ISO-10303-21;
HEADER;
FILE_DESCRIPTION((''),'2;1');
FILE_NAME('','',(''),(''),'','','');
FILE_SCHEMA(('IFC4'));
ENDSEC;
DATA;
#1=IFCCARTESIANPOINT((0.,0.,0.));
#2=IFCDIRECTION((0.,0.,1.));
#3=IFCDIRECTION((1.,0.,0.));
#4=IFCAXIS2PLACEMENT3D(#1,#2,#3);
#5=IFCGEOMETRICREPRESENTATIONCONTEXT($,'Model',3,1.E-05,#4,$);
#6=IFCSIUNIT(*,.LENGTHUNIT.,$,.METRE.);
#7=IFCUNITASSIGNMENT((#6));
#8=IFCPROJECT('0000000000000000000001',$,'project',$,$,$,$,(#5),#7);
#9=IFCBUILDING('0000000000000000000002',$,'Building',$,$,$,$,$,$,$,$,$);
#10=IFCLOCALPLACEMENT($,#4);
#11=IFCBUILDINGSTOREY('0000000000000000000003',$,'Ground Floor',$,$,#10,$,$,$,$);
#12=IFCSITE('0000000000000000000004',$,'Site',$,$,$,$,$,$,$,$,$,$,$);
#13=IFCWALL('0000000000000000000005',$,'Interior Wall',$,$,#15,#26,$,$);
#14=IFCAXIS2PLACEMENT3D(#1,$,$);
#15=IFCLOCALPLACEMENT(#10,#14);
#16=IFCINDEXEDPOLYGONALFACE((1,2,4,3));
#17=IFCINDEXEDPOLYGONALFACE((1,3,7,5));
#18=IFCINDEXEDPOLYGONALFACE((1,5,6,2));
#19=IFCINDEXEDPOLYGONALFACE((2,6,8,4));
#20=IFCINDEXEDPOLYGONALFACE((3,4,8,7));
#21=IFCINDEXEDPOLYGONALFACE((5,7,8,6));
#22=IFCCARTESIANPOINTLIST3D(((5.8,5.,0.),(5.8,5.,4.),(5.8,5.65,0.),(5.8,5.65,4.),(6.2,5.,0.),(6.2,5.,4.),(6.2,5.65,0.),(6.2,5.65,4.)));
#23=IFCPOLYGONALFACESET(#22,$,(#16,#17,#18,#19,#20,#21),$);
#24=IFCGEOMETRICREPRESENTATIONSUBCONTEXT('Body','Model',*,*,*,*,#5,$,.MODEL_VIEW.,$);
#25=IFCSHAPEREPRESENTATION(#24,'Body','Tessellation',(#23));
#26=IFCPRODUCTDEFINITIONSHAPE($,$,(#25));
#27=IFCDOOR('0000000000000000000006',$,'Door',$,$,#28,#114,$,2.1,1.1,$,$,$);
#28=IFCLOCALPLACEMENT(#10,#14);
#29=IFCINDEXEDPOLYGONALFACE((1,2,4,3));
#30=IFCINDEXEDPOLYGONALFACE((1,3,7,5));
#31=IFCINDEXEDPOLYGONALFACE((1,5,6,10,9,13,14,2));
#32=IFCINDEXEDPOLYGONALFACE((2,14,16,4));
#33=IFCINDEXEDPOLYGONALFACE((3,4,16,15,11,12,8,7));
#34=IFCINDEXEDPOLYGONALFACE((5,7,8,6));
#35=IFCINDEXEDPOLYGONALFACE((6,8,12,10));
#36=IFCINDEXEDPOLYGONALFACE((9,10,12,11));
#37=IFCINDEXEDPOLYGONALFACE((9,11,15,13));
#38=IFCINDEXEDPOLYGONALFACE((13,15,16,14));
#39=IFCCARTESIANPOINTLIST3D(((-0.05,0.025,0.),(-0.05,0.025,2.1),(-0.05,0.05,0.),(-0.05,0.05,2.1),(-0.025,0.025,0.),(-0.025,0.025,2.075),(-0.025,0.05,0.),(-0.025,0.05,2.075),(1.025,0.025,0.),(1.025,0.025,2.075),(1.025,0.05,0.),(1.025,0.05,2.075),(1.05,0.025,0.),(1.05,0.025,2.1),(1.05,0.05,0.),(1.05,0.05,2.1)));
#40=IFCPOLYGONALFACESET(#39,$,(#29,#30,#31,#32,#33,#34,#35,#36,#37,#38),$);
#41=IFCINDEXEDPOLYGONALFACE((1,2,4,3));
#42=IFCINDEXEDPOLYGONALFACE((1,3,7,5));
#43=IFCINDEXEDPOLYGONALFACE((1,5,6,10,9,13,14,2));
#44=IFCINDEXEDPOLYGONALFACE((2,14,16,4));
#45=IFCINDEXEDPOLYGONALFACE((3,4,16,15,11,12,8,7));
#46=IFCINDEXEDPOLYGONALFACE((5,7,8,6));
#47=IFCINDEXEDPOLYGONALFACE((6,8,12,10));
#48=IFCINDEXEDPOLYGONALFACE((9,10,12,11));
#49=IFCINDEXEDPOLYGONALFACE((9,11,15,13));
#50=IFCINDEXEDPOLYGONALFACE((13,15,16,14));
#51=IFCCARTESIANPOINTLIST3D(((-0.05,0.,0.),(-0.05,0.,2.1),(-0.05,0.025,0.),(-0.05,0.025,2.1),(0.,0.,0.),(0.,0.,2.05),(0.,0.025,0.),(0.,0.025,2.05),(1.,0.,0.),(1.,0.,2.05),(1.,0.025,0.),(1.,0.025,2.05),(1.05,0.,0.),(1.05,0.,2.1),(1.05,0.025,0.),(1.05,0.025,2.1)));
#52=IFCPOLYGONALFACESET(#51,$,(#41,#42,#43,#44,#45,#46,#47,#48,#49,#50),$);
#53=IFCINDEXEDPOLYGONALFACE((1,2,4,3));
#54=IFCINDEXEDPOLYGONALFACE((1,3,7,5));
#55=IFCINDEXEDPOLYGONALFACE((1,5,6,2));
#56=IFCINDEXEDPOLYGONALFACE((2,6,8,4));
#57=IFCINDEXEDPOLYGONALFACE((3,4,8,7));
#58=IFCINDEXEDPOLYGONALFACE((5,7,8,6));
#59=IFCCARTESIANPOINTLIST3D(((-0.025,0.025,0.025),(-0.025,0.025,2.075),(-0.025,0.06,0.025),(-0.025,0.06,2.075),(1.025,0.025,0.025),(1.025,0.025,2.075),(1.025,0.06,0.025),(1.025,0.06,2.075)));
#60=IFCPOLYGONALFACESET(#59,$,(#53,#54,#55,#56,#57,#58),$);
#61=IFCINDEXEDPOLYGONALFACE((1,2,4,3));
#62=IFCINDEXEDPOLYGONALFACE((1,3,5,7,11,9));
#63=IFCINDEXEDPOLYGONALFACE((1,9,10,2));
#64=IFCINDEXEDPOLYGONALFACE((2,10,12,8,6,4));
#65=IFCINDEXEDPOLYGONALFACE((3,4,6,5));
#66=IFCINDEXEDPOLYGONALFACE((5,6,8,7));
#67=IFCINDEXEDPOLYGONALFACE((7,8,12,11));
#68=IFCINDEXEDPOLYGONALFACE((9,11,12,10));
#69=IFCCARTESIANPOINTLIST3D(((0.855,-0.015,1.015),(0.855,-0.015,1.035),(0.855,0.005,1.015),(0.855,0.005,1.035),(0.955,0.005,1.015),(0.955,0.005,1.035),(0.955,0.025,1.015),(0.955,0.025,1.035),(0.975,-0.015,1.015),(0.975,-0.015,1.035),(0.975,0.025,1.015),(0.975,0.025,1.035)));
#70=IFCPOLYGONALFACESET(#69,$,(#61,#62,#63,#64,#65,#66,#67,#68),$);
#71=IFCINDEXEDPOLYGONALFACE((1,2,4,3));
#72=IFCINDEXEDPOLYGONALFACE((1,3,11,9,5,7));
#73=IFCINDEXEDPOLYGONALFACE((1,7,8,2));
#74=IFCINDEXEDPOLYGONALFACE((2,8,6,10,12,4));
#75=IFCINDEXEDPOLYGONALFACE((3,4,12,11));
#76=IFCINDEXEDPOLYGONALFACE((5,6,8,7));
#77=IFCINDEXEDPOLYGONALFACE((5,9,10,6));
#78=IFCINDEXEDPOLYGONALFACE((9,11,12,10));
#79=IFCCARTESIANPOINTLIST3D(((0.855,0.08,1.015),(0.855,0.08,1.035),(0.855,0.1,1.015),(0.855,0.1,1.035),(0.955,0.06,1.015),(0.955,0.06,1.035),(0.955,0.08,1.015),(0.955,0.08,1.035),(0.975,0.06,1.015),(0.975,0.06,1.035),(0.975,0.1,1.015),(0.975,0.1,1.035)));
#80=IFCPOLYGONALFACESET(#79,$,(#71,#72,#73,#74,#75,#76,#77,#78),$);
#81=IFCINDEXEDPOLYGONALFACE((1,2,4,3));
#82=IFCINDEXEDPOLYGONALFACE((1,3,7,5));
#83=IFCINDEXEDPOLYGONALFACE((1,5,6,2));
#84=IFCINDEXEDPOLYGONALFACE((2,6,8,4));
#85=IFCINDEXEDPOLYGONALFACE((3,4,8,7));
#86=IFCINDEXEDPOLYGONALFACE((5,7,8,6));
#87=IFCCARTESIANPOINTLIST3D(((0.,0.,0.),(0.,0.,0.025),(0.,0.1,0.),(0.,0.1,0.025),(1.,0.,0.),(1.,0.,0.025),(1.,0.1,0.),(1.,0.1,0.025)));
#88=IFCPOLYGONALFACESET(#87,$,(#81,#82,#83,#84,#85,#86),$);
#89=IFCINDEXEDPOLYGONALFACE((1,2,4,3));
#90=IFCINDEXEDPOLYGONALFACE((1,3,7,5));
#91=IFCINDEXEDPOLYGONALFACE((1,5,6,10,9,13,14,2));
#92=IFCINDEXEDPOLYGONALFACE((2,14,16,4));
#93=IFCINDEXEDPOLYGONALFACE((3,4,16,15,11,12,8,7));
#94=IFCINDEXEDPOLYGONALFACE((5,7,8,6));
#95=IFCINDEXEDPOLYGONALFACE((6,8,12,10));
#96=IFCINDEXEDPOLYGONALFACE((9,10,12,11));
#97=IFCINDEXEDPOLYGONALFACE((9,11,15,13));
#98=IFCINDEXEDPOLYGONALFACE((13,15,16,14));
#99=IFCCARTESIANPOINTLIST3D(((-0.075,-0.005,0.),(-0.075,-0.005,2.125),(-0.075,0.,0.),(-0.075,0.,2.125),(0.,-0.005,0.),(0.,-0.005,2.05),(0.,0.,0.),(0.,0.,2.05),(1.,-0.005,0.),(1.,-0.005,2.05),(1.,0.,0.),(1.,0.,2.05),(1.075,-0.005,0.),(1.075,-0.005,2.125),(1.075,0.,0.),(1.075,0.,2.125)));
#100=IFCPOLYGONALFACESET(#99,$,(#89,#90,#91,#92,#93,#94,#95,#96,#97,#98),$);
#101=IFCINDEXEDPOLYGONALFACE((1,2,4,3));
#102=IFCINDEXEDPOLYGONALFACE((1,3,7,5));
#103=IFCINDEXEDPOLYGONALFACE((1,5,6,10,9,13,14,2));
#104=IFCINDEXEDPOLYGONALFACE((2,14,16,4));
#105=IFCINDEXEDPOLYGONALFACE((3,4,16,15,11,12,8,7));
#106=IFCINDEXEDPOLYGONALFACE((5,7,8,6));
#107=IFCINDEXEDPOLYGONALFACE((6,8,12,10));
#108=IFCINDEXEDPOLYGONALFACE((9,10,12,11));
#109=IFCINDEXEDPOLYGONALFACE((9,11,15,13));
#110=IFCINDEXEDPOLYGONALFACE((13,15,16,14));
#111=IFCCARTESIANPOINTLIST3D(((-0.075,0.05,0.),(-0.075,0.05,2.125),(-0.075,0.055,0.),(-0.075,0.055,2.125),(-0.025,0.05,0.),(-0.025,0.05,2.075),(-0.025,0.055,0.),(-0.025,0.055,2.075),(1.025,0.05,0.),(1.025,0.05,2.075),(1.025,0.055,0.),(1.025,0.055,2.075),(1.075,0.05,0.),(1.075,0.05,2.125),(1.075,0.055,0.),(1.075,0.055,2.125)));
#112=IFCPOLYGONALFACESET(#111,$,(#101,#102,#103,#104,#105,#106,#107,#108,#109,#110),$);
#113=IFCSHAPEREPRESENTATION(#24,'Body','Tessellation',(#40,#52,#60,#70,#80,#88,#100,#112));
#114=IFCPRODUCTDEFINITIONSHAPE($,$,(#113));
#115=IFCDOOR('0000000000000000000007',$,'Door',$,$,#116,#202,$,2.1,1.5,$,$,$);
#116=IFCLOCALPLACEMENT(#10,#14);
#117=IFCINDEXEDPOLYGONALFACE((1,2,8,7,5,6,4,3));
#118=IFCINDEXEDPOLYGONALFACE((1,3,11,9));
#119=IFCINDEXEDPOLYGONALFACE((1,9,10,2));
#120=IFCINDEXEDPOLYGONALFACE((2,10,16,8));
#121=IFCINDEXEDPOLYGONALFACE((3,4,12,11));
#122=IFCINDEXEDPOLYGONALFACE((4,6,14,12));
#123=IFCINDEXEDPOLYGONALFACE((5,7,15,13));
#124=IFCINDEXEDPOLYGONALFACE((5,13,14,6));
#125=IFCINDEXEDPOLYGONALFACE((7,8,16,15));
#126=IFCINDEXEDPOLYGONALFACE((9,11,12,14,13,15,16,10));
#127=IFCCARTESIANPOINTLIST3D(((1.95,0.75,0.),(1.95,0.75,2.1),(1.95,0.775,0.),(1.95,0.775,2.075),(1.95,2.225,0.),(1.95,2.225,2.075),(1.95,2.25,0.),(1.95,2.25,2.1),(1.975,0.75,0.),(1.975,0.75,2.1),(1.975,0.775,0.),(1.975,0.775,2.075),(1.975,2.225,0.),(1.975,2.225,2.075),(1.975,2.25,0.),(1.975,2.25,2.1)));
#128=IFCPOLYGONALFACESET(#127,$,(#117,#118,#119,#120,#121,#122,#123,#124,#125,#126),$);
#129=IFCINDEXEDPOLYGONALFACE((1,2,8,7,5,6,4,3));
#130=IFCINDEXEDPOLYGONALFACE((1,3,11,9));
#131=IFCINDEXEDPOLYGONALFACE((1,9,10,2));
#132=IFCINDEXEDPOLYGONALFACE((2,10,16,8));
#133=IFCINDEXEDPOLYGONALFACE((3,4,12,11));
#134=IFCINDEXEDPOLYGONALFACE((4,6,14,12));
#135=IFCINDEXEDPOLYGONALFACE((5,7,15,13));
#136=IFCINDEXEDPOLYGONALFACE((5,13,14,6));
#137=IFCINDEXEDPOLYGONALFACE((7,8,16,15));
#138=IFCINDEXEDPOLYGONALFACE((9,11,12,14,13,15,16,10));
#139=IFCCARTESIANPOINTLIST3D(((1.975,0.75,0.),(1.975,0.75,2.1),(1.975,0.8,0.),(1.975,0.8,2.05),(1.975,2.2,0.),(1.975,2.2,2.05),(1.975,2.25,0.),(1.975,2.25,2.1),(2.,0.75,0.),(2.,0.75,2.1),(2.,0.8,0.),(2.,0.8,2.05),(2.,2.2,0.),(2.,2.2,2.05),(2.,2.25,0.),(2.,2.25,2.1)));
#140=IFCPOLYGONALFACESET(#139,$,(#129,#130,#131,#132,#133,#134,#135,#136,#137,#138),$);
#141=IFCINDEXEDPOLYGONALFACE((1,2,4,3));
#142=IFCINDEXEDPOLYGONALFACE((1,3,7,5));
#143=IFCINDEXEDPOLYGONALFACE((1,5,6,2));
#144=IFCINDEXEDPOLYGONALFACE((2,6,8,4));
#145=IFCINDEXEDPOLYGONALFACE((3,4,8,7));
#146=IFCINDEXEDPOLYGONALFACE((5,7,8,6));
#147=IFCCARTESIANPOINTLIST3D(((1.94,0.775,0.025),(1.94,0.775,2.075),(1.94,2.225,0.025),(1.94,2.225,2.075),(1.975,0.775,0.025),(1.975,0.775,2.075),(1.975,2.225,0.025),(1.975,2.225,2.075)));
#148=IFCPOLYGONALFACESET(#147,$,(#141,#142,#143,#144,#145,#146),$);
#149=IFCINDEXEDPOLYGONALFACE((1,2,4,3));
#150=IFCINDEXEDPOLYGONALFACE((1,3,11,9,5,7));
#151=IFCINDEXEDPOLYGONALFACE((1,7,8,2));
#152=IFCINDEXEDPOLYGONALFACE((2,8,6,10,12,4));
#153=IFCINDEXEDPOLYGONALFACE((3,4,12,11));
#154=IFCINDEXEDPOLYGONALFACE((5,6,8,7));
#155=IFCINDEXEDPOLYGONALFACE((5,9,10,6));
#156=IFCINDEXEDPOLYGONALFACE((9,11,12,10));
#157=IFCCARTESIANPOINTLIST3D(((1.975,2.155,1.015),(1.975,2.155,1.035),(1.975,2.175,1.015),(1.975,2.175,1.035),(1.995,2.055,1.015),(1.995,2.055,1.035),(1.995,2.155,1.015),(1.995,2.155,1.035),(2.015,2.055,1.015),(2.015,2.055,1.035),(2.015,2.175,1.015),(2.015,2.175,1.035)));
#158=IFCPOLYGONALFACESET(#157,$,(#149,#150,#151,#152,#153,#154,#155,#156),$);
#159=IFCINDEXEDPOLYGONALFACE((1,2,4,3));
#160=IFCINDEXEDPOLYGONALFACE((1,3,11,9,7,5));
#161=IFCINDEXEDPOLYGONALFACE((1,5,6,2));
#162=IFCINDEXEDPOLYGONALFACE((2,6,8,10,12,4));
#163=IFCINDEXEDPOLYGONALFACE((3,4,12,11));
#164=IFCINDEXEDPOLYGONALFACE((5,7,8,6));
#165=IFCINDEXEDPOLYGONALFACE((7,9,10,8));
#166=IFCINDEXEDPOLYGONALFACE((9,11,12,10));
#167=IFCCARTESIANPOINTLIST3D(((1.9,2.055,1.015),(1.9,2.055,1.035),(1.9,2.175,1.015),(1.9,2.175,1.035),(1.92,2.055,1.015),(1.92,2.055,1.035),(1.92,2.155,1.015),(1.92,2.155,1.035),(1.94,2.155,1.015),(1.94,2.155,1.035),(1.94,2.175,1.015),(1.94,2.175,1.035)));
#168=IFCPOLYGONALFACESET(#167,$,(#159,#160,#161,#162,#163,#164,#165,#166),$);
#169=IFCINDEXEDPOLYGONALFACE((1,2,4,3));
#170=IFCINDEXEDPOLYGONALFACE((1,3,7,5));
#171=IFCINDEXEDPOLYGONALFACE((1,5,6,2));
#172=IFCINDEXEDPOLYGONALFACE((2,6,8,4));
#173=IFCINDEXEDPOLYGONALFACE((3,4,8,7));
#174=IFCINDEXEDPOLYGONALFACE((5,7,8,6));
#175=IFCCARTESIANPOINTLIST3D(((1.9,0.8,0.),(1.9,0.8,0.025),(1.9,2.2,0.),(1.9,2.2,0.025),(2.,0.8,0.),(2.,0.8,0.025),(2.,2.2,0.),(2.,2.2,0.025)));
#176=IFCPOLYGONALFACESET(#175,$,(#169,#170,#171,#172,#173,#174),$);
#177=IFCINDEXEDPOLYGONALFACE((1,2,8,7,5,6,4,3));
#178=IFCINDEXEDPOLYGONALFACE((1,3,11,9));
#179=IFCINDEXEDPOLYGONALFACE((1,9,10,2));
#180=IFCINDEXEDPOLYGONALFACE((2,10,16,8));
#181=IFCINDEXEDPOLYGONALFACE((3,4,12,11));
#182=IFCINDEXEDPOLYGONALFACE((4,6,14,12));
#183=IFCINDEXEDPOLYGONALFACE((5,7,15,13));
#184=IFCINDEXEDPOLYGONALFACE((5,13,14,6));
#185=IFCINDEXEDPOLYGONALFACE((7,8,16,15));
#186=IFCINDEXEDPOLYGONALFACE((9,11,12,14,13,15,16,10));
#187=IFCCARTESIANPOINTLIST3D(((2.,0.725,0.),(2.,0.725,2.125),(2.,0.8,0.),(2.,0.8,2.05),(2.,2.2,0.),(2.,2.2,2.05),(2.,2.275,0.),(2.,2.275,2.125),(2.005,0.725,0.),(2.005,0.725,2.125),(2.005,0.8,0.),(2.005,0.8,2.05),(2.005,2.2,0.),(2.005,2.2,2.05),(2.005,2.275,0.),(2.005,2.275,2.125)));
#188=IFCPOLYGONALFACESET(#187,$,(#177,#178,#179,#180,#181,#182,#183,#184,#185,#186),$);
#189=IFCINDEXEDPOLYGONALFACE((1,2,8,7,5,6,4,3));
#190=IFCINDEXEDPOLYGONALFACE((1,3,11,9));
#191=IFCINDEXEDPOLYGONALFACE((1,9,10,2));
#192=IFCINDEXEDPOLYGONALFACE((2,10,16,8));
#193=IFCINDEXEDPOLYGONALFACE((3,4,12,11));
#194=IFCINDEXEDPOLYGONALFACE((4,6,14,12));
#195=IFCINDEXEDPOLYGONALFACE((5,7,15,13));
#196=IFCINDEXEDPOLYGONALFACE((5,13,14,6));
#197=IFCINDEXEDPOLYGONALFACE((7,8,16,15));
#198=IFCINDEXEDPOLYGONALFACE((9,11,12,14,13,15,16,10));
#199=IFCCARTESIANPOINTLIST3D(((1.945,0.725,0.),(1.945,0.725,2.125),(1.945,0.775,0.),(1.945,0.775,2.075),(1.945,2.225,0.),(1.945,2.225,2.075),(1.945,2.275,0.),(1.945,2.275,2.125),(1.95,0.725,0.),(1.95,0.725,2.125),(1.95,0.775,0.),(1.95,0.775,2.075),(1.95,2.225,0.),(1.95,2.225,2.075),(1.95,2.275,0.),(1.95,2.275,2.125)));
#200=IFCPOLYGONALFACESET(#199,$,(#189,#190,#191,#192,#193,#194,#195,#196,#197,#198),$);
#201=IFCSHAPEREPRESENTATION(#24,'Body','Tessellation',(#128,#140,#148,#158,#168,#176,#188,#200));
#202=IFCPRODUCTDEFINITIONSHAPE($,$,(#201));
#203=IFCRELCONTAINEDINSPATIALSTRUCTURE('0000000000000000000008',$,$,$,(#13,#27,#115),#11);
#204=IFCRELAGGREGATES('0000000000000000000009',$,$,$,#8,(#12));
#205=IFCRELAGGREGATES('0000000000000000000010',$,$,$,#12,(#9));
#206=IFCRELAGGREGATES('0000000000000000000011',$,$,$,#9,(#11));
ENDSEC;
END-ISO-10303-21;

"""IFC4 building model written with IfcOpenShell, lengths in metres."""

from ifc_helpers import new_model, si_unit, frame, origin_with_axes, place, context, subcontext, project, spatial, line, indexed_curve, outline, extrude, element, save


model = new_model("IFC4")

# Units and contexts
model_context = context("Model", 3, precision=1e-05, world=origin_with_axes())
body_context = subcontext(model_context, "Body", "Model", "MODEL_VIEW")
ifc_project = project(units=[si_unit("LENGTHUNIT", "METRE")], contexts=[model_context])

# Site, building, storey
site = spatial("IfcSite", under=ifc_project, Name="Site")
building = spatial("IfcBuilding", under=site, Name="Building")
storey_placement = place(None, origin_with_axes())
storey = spatial("IfcBuildingStorey", under=building, at=storey_placement, Name="Ground Floor")

# Wall
wall_1_placement = place(storey_placement, frame((6.0, 5.0, 0.0), z_axis=(0.0, 0.0, 1.0), x_axis=(0.0, 1.0, 0.0)))
element("IfcWall", 1, at=wall_1_placement, inside=storey, Name="Interior Wall", context=body_context, shape_type="SweptSolid", body=[
    extrude(outline(indexed_curve([(0.0, 0.0), (0.0, 0.4), (0.65, 0.4), (0.65, 0.0), (0.0, 0.0)], self_intersect=False)), frame((0.0, -0.2, 0.0), z_axis=(0.0, 0.0, 1.0), x_axis=(1.0, 0.0, 0.0)), (0.0, 0.0, 1.0), 4.0),
])

# Doors
door_1_placement = place(storey_placement, frame((-0.05, 0.0, 0.0), z_axis=(0.0, 0.0, 1.0), x_axis=(1.0, 0.0, 0.0)))
element("IfcDoor", 2, at=door_1_placement, inside=storey, Name="Door", OverallHeight=2.1, OverallWidth=1.1, context=body_context, shape_type="SweptSolid", body=[
    extrude(outline(indexed_curve([(0.0, 0.0), (0.0, 2.1), (1.1, 2.1), (1.1, 0.0), (1.075, 0.0), (1.075, 2.075), (0.025, 2.075), (0.025, 0.0)], segments=[line(1, 2, 3, 4, 5, 6, 7, 8, 1)])), frame((0.0, 0.025, 0.0), z_axis=(0.0, -1.0, 0.0), x_axis=(1.0, 0.0, 0.0)), (0.0, 0.0, -1.0), 0.025),
    extrude(outline(indexed_curve([(0.0, 0.0), (0.0, 2.1), (1.1, 2.1), (1.1, 0.0), (1.05, 0.0), (1.05, 2.05), (0.05, 2.05), (0.05, 0.0)], segments=[line(1, 2, 3, 4, 5, 6, 7, 8, 1)])), frame((0.0, 0.0, 0.0), z_axis=(0.0, -1.0, 0.0), x_axis=(1.0, 0.0, 0.0)), (0.0, 0.0, -1.0), 0.025),
    extrude(outline(indexed_curve([(0.0, 0.0), (1.05, 0.0), (1.05, 0.035), (0.0, 0.035)], segments=[line(1, 2, 3, 4, 1)])), frame((0.025, 0.025, 0.025), z_axis=(0.0, 0.0, 1.0), x_axis=(1.0, 0.0, 0.0)), (0.0, 0.0, 1.0), 2.05),
    extrude(outline(indexed_curve([(0.0, 0.0), (0.0, -0.04), (-0.12, -0.04), (-0.12, -0.02), (-0.02, -0.02), (-0.02, 0.0)], segments=[line(1, 2, 3, 4, 5, 6, 1)])), frame((1.025, 0.025, 1.015), z_axis=(0.0, 0.0, 1.0), x_axis=(1.0, 0.0, 0.0)), (0.0, 0.0, 1.0), 0.02),
    extrude(outline(indexed_curve([(0.0, 0.0), (0.0, 0.04), (-0.12, 0.04), (-0.12, 0.02), (-0.02, 0.02), (-0.02, 0.0)], segments=[line(1, 2, 3, 4, 5, 6, 1)])), frame((1.025, 0.06, 1.015), z_axis=(0.0, 0.0, 1.0), x_axis=(1.0, 0.0, 0.0)), (0.0, 0.0, 1.0), 0.02),
    extrude(outline(indexed_curve([(0.0, 0.0), (1.0, 0.0), (1.0, 0.1), (0.0, 0.1)], segments=[line(1, 2, 3, 4, 1)])), frame((0.05, 0.0, 0.0), z_axis=(0.0, 0.0, 1.0), x_axis=(1.0, 0.0, 0.0)), (0.0, 0.0, 1.0), 0.025),
    extrude(outline(indexed_curve([(0.0, 0.0), (0.0, 2.125), (1.15, 2.125), (1.15, 0.0), (1.075, 0.0), (1.075, 2.05), (0.075, 2.05), (0.075, 0.0)], segments=[line(1, 2, 3, 4, 5, 6, 7, 8, 1)])), frame((-0.025, -0.005, 0.0), z_axis=(0.0, -1.0, 0.0), x_axis=(1.0, 0.0, 0.0)), (0.0, 0.0, -1.0), 0.005),
    extrude(outline(indexed_curve([(0.0, 0.0), (0.0, 2.125), (1.15, 2.125), (1.15, 0.0), (1.1, 0.0), (1.1, 2.075), (0.05, 2.075), (0.05, 0.0)], segments=[line(1, 2, 3, 4, 5, 6, 7, 8, 1)])), frame((-0.025, 0.05, 0.0), z_axis=(0.0, -1.0, 0.0), x_axis=(1.0, 0.0, 0.0)), (0.0, 0.0, -1.0), 0.005),
])
door_2_placement = place(storey_placement, frame((2.0, 0.75, 0.0), z_axis=(0.0, 0.0, 1.0), x_axis=(0.0, 1.0, 0.0)))
element("IfcDoor", 3, at=door_2_placement, inside=storey, Name="Door", OverallHeight=2.1, OverallWidth=1.5, context=body_context, shape_type="SweptSolid", body=[
    extrude(outline(indexed_curve([(0.0, 0.0), (0.0, 2.1), (1.5, 2.1), (1.5, 0.0), (1.475, 0.0), (1.475, 2.075), (0.025, 2.075), (0.025, 0.0)], segments=[line(1, 2, 3, 4, 5, 6, 7, 8, 1)])), frame((0.0, 0.025, 0.0), z_axis=(0.0, -1.0, 0.0), x_axis=(1.0, 0.0, 0.0)), (0.0, 0.0, -1.0), 0.025),
    extrude(outline(indexed_curve([(0.0, 0.0), (0.0, 2.1), (1.5, 2.1), (1.5, 0.0), (1.45, 0.0), (1.45, 2.05), (0.05, 2.05), (0.05, 0.0)], segments=[line(1, 2, 3, 4, 5, 6, 7, 8, 1)])), frame((0.0, 0.0, 0.0), z_axis=(0.0, -1.0, 0.0), x_axis=(1.0, 0.0, 0.0)), (0.0, 0.0, -1.0), 0.025),
    extrude(outline(indexed_curve([(0.0, 0.0), (1.45, 0.0), (1.45, 0.035), (0.0, 0.035)], segments=[line(1, 2, 3, 4, 1)])), frame((0.025, 0.025, 0.025), z_axis=(0.0, 0.0, 1.0), x_axis=(1.0, 0.0, 0.0)), (0.0, 0.0, 1.0), 2.05),
    extrude(outline(indexed_curve([(0.0, 0.0), (0.0, -0.04), (-0.12, -0.04), (-0.12, -0.02), (-0.02, -0.02), (-0.02, 0.0)], segments=[line(1, 2, 3, 4, 5, 6, 1)])), frame((1.425, 0.025, 1.015), z_axis=(0.0, 0.0, 1.0), x_axis=(1.0, 0.0, 0.0)), (0.0, 0.0, 1.0), 0.02),
    extrude(outline(indexed_curve([(0.0, 0.0), (0.0, 0.04), (-0.12, 0.04), (-0.12, 0.02), (-0.02, 0.02), (-0.02, 0.0)], segments=[line(1, 2, 3, 4, 5, 6, 1)])), frame((1.425, 0.06, 1.015), z_axis=(0.0, 0.0, 1.0), x_axis=(1.0, 0.0, 0.0)), (0.0, 0.0, 1.0), 0.02),
    extrude(outline(indexed_curve([(0.0, 0.0), (1.4, 0.0), (1.4, 0.1), (0.0, 0.1)], segments=[line(1, 2, 3, 4, 1)])), frame((0.05, 0.0, 0.0), z_axis=(0.0, 0.0, 1.0), x_axis=(1.0, 0.0, 0.0)), (0.0, 0.0, 1.0), 0.025),
    extrude(outline(indexed_curve([(0.0, 0.0), (0.0, 2.125), (1.55, 2.125), (1.55, 0.0), (1.475, 0.0), (1.475, 2.05), (0.075, 2.05), (0.075, 0.0)], segments=[line(1, 2, 3, 4, 5, 6, 7, 8, 1)])), frame((-0.025, -0.005, 0.0), z_axis=(0.0, -1.0, 0.0), x_axis=(1.0, 0.0, 0.0)), (0.0, 0.0, -1.0), 0.005),
    extrude(outline(indexed_curve([(0.0, 0.0), (0.0, 2.125), (1.55, 2.125), (1.55, 0.0), (1.5, 0.0), (1.5, 2.075), (0.05, 2.075), (0.05, 0.0)], segments=[line(1, 2, 3, 4, 5, 6, 7, 8, 1)])), frame((-0.025, 0.05, 0.0), z_axis=(0.0, -1.0, 0.0), x_axis=(1.0, 0.0, 0.0)), (0.0, 0.0, -1.0), 0.005),
])

save(model, "model.ifc")
